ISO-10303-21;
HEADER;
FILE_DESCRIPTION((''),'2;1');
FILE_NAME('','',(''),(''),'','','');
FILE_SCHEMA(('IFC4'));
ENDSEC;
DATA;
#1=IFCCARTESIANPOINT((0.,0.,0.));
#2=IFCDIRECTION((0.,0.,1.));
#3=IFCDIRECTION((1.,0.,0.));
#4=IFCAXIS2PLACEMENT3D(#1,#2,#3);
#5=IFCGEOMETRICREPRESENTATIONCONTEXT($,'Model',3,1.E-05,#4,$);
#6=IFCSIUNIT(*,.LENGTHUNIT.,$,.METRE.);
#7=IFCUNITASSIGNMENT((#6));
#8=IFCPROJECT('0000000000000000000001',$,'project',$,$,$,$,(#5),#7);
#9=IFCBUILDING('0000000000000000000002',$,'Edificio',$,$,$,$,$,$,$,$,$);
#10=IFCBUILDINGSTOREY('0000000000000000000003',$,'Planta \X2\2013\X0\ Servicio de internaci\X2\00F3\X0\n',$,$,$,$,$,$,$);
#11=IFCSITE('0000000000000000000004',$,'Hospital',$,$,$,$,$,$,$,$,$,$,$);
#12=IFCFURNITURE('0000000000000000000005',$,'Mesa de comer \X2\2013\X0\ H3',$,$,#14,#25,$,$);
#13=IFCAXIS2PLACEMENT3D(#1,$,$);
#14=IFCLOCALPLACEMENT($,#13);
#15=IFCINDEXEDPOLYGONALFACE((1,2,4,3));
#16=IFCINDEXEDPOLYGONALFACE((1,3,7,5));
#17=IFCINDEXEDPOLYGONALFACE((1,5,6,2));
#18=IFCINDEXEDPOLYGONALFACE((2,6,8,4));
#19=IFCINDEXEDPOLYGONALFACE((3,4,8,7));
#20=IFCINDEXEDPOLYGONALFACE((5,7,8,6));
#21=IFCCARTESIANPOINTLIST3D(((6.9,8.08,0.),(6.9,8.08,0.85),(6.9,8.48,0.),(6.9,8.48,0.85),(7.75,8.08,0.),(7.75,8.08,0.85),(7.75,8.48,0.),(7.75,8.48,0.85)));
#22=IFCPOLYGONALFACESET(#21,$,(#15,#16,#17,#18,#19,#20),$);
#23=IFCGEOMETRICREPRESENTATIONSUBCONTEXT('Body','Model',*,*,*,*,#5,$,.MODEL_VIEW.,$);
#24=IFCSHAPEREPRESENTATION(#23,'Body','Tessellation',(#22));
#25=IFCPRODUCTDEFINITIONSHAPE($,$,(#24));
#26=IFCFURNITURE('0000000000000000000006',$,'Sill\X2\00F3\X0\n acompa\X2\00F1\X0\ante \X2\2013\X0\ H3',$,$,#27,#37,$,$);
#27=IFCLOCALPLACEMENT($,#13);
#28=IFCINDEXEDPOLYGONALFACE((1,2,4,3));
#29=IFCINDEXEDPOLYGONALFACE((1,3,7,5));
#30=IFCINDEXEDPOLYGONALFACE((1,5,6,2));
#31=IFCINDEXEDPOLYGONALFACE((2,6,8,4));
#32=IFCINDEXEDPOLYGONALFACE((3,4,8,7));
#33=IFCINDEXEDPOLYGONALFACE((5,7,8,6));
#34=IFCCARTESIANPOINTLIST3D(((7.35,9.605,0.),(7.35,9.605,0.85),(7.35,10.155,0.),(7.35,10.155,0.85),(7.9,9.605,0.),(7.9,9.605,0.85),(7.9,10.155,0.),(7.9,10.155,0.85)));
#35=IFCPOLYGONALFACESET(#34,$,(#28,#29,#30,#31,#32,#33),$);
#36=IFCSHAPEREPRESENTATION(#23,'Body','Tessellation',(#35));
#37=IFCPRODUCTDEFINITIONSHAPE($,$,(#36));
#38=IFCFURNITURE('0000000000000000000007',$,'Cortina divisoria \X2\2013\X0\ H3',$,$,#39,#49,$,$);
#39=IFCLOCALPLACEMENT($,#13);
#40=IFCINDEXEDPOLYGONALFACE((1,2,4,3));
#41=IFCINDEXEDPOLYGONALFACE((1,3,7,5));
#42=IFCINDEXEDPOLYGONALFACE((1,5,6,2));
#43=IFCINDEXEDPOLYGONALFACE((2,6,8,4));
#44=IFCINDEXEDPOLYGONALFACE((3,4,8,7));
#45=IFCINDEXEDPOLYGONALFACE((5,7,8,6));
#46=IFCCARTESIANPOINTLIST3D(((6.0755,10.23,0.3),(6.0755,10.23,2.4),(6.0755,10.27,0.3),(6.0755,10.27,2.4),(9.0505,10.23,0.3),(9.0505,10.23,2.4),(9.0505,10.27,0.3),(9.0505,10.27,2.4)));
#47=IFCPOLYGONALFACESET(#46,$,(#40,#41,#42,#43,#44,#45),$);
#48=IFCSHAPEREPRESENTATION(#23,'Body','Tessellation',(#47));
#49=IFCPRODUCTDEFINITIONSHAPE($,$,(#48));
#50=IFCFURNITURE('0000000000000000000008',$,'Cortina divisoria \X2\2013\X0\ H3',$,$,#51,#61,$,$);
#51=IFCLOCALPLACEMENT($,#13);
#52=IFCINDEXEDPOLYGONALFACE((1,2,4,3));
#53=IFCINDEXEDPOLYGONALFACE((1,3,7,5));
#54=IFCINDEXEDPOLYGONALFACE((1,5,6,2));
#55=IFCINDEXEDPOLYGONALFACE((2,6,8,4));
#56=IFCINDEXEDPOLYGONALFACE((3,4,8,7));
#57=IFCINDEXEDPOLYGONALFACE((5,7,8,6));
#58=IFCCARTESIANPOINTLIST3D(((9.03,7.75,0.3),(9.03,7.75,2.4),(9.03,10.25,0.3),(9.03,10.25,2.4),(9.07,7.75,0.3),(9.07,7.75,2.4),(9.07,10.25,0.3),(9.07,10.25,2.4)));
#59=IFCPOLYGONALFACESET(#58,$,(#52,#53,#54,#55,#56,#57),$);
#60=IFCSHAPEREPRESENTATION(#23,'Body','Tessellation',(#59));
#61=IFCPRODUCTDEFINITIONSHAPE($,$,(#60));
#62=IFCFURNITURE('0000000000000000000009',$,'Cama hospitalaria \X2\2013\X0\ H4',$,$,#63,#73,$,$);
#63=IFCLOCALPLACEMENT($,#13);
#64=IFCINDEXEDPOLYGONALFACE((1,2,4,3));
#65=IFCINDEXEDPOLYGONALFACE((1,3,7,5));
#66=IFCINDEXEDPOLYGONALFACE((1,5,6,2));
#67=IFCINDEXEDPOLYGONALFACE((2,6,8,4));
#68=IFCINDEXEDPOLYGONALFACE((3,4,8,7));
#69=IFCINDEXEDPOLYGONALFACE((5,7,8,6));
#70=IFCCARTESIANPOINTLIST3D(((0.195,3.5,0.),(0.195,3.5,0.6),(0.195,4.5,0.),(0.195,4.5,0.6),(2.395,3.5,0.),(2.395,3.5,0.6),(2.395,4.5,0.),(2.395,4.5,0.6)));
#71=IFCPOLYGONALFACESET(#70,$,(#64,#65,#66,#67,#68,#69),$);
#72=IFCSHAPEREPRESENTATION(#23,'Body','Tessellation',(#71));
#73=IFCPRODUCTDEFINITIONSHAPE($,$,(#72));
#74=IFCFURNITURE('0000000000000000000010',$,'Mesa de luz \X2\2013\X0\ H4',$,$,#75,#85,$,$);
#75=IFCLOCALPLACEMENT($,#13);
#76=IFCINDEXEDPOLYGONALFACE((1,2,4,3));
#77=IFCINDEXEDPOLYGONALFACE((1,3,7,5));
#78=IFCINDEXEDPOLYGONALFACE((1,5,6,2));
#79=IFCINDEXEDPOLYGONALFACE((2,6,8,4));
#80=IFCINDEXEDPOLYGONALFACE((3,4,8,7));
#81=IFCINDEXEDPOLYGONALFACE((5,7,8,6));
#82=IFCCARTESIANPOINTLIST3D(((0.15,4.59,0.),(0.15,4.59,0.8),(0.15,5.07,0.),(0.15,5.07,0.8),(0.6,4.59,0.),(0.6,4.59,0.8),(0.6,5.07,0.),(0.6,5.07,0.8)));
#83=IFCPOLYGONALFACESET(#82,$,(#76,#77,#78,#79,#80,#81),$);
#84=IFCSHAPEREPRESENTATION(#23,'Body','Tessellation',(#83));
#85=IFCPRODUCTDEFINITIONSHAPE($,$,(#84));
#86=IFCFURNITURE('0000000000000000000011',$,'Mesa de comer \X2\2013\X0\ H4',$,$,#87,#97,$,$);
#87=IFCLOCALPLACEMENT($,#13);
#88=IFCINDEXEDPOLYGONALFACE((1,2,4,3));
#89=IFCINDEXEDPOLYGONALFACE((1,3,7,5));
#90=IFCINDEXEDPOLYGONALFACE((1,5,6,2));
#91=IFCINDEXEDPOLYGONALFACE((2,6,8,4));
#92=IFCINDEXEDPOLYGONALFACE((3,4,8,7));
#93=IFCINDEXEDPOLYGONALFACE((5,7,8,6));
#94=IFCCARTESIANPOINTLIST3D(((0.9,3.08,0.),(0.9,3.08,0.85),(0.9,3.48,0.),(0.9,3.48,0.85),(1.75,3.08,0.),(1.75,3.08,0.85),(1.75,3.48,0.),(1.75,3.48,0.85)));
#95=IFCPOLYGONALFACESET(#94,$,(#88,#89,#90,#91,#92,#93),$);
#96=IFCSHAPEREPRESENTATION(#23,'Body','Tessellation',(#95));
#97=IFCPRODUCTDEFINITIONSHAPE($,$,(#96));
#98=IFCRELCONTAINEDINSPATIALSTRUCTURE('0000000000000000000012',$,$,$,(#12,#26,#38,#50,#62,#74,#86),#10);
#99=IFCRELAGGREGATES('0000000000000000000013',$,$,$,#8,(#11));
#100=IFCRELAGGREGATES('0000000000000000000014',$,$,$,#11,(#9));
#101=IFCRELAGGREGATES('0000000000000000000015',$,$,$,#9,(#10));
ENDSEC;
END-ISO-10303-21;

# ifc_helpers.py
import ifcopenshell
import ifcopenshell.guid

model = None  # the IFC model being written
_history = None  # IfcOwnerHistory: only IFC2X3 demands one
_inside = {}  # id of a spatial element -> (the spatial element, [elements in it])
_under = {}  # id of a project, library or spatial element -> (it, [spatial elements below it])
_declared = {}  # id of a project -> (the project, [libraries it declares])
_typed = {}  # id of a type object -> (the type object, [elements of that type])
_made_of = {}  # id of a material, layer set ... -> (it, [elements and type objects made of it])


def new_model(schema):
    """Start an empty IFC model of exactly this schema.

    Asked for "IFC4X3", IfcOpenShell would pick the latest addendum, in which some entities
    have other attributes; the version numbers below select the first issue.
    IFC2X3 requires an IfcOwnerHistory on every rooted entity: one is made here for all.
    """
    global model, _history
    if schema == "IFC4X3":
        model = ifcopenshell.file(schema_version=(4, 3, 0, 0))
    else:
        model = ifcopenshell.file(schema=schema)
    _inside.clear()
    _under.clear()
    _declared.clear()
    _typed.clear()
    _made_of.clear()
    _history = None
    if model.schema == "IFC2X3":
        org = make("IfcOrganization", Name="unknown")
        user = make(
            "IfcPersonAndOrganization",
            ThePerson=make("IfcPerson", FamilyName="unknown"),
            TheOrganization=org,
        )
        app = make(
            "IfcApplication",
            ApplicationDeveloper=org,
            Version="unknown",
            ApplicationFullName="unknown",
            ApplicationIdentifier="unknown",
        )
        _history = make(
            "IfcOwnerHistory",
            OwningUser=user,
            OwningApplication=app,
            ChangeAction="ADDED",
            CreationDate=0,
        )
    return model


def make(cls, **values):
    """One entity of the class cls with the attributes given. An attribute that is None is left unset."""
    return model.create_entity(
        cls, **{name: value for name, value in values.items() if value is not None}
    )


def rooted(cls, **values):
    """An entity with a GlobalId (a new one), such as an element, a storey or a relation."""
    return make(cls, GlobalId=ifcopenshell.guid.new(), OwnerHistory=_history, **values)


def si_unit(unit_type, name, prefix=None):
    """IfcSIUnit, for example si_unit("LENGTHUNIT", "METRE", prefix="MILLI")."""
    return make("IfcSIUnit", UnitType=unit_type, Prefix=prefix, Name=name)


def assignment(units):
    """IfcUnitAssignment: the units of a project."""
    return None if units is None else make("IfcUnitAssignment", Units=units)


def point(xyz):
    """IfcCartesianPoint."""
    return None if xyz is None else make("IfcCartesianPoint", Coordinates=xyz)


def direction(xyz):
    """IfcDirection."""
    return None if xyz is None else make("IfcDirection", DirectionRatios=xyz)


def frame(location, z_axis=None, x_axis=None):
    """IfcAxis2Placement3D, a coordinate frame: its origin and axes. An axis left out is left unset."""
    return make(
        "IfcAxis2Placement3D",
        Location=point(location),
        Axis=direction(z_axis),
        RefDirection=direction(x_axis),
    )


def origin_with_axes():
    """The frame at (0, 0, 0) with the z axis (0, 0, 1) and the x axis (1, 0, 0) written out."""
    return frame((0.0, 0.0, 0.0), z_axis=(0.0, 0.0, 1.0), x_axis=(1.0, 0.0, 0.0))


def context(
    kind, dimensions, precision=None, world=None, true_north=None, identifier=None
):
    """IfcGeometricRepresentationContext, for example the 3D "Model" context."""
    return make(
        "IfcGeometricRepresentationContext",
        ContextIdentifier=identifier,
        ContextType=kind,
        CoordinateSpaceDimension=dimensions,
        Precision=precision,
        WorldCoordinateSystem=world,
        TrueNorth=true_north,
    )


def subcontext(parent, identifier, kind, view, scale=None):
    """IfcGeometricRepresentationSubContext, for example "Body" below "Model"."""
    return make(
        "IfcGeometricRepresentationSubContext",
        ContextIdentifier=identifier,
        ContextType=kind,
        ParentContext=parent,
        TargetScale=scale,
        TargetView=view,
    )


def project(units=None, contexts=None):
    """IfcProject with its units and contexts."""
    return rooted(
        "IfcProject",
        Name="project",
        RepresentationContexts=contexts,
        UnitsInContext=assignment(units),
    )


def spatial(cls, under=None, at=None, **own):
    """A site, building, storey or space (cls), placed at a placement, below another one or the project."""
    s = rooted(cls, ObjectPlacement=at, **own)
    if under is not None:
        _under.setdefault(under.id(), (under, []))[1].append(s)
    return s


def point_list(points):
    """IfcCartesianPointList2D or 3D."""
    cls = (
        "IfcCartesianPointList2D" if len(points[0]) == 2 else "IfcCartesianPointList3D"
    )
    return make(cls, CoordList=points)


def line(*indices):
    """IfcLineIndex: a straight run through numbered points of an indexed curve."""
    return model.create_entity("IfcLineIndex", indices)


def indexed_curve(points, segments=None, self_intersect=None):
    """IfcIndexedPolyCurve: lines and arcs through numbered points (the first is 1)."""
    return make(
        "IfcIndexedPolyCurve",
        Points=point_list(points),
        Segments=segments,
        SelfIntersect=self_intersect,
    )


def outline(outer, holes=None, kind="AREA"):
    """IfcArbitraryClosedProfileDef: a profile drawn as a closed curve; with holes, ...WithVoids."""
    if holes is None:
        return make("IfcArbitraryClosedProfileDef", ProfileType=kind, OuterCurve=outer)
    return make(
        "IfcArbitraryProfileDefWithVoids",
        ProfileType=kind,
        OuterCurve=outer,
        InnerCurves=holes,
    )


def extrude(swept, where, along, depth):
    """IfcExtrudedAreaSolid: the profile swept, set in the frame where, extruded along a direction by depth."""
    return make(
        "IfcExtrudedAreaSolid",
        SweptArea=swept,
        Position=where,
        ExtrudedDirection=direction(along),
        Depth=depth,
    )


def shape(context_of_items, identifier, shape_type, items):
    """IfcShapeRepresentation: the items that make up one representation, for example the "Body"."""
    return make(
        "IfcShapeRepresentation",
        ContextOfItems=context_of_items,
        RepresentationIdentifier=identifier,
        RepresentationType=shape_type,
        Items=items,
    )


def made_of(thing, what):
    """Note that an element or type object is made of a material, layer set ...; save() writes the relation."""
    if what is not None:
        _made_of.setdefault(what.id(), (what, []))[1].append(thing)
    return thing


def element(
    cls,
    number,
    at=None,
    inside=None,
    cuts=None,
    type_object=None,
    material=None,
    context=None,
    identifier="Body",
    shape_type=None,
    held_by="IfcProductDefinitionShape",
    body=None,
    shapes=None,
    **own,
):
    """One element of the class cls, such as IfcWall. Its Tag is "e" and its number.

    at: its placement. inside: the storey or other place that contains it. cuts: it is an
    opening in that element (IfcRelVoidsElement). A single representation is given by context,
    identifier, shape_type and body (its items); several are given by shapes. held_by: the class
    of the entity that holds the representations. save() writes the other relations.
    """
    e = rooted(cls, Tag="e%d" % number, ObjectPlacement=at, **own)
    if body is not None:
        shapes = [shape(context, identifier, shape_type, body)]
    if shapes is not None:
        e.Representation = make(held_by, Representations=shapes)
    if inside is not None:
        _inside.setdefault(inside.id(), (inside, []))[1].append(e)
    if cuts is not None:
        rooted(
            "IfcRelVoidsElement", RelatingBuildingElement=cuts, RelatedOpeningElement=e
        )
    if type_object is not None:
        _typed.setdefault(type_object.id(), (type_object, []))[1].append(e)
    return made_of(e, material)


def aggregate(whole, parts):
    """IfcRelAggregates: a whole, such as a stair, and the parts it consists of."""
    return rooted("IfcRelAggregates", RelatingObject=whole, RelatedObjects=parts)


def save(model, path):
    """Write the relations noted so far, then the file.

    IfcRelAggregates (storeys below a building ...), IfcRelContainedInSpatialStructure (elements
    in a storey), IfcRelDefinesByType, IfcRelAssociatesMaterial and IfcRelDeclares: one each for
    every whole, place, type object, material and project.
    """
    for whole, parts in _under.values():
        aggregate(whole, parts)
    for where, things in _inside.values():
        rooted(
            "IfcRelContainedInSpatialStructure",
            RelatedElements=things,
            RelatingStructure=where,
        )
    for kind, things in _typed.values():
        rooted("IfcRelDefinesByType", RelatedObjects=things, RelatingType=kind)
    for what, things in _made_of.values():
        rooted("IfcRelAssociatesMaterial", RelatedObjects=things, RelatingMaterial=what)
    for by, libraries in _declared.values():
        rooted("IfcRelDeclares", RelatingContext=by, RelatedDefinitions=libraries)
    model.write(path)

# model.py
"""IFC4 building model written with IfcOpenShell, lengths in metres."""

from ifc_helpers import new_model, si_unit, frame, origin_with_axes, context, subcontext, project, spatial, line, indexed_curve, outline, extrude, element, save


model = new_model("IFC4")

# Units and contexts
model_context = context("Model", 3, precision=1e-05, world=origin_with_axes())
body_context = subcontext(model_context, "Body", "Model", "MODEL_VIEW")
ifc_project = project(units=[si_unit("LENGTHUNIT", "METRE")], contexts=[model_context])

# Site, building, storey
site = spatial("IfcSite", under=ifc_project, Name="Hospital")
building = spatial("IfcBuilding", under=site, Name="Edificio")
storey = spatial("IfcBuildingStorey", under=building, Name="Planta – Servicio de internación")

# Furniture
element("IfcFurniture", 1, inside=storey, Name="Mesa de comer – H3", context=body_context, shape_type="SweptSolid", body=[
    extrude(outline(indexed_curve([(0.0, 0.0), (0.85, 0.0), (0.85, 0.4), (0.0, 0.4)], segments=[line(1, 2, 3, 4, 1)])), frame((6.9, 8.08, 0.0), z_axis=(0.0, 0.0, 1.0), x_axis=(1.0, 0.0, 0.0)), (0.0, 0.0, 1.0), 0.85),
])
element("IfcFurniture", 2, inside=storey, Name="Sillón acompañante – H3", context=body_context, shape_type="SweptSolid", body=[
    extrude(outline(indexed_curve([(0.0, 0.0), (0.55, 0.0), (0.55, 0.55), (0.0, 0.55)], segments=[line(1, 2, 3, 4, 1)])), frame((7.35, 9.605, 0.0), z_axis=(0.0, 0.0, 1.0), x_axis=(1.0, 0.0, 0.0)), (0.0, 0.0, 1.0), 0.85),
])
element("IfcFurniture", 3, inside=storey, Name="Cortina divisoria – H3", context=body_context, shape_type="SweptSolid", body=[
    extrude(outline(indexed_curve([(0.0, 0.0), (2.975, 0.0), (2.975, 0.04), (0.0, 0.04)], segments=[line(1, 2, 3, 4, 1)])), frame((6.0755, 10.23, 0.3), z_axis=(0.0, 0.0, 1.0), x_axis=(1.0, 0.0, 0.0)), (0.0, 0.0, 1.0), 2.1),
])
element("IfcFurniture", 4, inside=storey, Name="Cortina divisoria – H3", context=body_context, shape_type="SweptSolid", body=[
    extrude(outline(indexed_curve([(0.0, 0.0), (0.04, 0.0), (0.04, 2.5), (0.0, 2.5)], segments=[line(1, 2, 3, 4, 1)])), frame((9.03, 7.75, 0.3), z_axis=(0.0, 0.0, 1.0), x_axis=(1.0, 0.0, 0.0)), (0.0, 0.0, 1.0), 2.1),
])
element("IfcFurniture", 5, inside=storey, Name="Cama hospitalaria – H4", context=body_context, shape_type="SweptSolid", body=[
    extrude(outline(indexed_curve([(0.0, 0.0), (2.2, 0.0), (2.2, 1.0), (0.0, 1.0)], segments=[line(1, 2, 3, 4, 1)])), frame((0.195, 3.5, 0.0), z_axis=(0.0, 0.0, 1.0), x_axis=(1.0, 0.0, 0.0)), (0.0, 0.0, 1.0), 0.6),
])
element("IfcFurniture", 6, inside=storey, Name="Mesa de luz – H4", context=body_context, shape_type="SweptSolid", body=[
    extrude(outline(indexed_curve([(0.0, 0.0), (0.45, 0.0), (0.45, 0.48), (0.0, 0.48)], segments=[line(1, 2, 3, 4, 1)])), frame((0.15, 4.59, 0.0), z_axis=(0.0, 0.0, 1.0), x_axis=(1.0, 0.0, 0.0)), (0.0, 0.0, 1.0), 0.8),
])
element("IfcFurniture", 7, inside=storey, Name="Mesa de comer – H4", context=body_context, shape_type="SweptSolid", body=[
    extrude(outline(indexed_curve([(0.0, 0.0), (0.85, 0.0), (0.85, 0.4), (0.0, 0.4)], segments=[line(1, 2, 3, 4, 1)])), frame((0.9, 3.08, 0.0), z_axis=(0.0, 0.0, 1.0), x_axis=(1.0, 0.0, 0.0)), (0.0, 0.0, 1.0), 0.85),
])

save(model, "model.ifc")
